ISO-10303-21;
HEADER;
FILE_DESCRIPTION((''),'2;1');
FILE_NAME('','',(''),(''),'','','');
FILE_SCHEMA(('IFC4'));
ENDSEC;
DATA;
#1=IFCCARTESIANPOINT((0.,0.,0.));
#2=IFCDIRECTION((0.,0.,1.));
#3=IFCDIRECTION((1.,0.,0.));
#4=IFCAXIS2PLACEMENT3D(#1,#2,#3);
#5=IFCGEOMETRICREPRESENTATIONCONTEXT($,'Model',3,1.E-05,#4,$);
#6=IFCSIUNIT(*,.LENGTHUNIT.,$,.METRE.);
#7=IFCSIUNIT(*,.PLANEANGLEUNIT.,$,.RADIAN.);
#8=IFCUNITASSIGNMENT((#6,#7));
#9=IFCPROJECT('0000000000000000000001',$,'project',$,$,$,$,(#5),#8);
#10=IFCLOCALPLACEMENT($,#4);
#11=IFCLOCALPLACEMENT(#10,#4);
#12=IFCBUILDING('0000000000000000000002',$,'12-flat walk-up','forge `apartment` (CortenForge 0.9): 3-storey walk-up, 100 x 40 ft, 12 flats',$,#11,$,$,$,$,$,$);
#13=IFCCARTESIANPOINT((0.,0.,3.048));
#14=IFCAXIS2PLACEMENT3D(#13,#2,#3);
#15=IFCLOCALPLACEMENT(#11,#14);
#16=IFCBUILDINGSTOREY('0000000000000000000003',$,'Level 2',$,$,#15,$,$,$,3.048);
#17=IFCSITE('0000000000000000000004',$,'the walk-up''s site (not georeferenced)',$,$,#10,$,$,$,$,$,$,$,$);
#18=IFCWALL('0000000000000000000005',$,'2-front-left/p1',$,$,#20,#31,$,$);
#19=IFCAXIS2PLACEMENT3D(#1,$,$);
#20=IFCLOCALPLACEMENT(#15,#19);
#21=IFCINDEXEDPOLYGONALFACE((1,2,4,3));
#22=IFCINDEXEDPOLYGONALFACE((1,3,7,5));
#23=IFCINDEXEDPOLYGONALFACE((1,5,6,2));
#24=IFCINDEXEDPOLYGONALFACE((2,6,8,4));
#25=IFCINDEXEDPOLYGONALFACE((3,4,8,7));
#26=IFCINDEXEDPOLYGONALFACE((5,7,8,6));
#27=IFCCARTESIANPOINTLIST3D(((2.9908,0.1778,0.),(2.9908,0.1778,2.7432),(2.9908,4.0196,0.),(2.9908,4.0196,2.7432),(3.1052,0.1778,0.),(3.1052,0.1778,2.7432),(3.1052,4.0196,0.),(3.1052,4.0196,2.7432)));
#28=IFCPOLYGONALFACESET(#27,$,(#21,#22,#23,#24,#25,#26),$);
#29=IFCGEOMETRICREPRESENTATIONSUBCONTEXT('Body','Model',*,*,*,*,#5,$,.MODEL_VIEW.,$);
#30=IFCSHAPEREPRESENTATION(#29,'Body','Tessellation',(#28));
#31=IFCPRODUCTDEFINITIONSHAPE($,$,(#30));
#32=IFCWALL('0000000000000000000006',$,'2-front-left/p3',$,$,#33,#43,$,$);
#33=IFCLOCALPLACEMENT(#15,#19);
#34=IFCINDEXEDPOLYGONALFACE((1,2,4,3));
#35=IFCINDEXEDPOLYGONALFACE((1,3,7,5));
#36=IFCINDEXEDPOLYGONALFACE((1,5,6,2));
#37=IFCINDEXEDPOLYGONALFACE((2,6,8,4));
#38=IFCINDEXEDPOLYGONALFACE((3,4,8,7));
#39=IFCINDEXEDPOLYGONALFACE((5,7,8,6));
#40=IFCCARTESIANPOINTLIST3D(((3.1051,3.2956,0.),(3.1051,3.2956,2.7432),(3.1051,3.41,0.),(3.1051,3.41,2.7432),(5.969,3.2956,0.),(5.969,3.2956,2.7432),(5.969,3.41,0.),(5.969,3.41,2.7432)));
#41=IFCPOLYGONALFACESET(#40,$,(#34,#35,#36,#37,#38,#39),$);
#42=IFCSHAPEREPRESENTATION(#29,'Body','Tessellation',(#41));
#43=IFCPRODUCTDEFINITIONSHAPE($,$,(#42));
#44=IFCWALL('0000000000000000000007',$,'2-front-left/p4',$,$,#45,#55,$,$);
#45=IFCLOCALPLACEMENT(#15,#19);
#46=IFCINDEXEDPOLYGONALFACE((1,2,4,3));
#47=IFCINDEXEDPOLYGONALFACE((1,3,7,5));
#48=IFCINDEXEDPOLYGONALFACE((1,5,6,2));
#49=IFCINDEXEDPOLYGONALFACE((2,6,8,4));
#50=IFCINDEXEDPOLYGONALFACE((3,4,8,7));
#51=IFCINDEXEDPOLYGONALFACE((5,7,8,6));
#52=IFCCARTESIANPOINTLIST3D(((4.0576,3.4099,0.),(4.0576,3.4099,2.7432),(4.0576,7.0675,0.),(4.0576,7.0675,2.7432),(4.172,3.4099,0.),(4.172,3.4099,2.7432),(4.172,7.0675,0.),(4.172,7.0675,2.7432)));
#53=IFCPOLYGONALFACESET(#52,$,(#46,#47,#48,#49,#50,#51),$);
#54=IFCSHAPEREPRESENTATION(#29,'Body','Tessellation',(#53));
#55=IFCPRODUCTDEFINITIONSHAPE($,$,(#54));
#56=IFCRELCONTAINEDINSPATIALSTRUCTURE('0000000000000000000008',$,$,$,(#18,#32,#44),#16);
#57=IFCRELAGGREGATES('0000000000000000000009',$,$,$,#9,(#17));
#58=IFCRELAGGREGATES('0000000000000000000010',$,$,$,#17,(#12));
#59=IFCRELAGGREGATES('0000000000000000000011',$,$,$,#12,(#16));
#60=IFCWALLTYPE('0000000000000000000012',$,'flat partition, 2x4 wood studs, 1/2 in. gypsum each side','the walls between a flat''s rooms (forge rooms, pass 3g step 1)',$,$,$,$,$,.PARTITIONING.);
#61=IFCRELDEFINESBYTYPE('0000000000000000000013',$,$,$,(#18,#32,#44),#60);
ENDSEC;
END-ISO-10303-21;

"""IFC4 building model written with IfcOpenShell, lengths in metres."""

from ifc_helpers import new_model, si_unit, frame, frame_2d, origin, origin_with_axes, place, context, subcontext, project, spatial, rectangle, extrude, type_object, element, save


model = new_model("IFC4")

# Units and contexts
model_context = context("Model", 3, precision=1e-05, world=origin_with_axes())
body_context = subcontext(model_context, "Body", "Model", "MODEL_VIEW")
ifc_project = project(units=[si_unit("LENGTHUNIT", "METRE"), si_unit("PLANEANGLEUNIT", "RADIAN")], contexts=[model_context])

# Site, building, storey
site_placement = place(None, origin_with_axes())
site = spatial("IfcSite", under=ifc_project, at=site_placement, Name="the walk-up's site (not georeferenced)")
building_placement = place(site_placement, origin_with_axes())
building = spatial("IfcBuilding", under=site, at=building_placement, Name="12-flat walk-up", Description="forge `apartment` (CortenForge 0.9): 3-storey walk-up, 100 x 40 ft, 12 flats")
storey_placement = place(building_placement, frame((0.0, 0.0, 3.048), z_axis=(0.0, 0.0, 1.0), x_axis=(1.0, 0.0, 0.0)))
storey = spatial("IfcBuildingStorey", under=building, at=storey_placement, Name="Level 2", Elevation=3.048)

# Walls
wall_type = type_object("IfcWallType", Name="flat partition, 2x4 wood studs, 1/2 in. gypsum each side", Description="the walls between a flat's rooms (forge rooms, pass 3g step 1)", PredefinedType="PARTITIONING")
wall_1_placement = place(storey_placement, frame((2.9909, 0.1778, 0.0), z_axis=(0.0, 0.0, 1.0), x_axis=(1.0, 0.0, 0.0)))
element("IfcWall", 1, at=wall_1_placement, inside=storey, type_object=wall_type, Name="2-front-left/p1", context=body_context, shape_type="SweptSolid", body=[
    extrude(rectangle(XDim=0.1143, YDim=3.8417, at=frame_2d((0.0572, 1.9209))), origin(), (0.0, 0.0, 1.0), 2.7432),
])
wall_2_placement = place(storey_placement, frame((3.1051, 3.2957, 0.0), z_axis=(0.0, 0.0, 1.0), x_axis=(1.0, 0.0, 0.0)))
element("IfcWall", 2, at=wall_2_placement, inside=storey, type_object=wall_type, Name="2-front-left/p3", context=body_context, shape_type="SweptSolid", body=[
    extrude(rectangle(XDim=2.8639, YDim=0.1143, at=frame_2d((1.4319, 0.0571))), origin(), (0.0, 0.0, 1.0), 2.7432),
])
wall_3_placement = place(storey_placement, frame((4.0576, 3.4099, 0.0), z_axis=(0.0, 0.0, 1.0), x_axis=(1.0, 0.0, 0.0)))
element("IfcWall", 3, at=wall_3_placement, inside=storey, type_object=wall_type, Name="2-front-left/p4", context=body_context, shape_type="SweptSolid", body=[
    extrude(rectangle(XDim=0.1143, YDim=3.6576, at=frame_2d((0.0572, 1.8288))), origin(), (0.0, 0.0, 1.0), 2.7432),
])

save(model, "model.ifc")
